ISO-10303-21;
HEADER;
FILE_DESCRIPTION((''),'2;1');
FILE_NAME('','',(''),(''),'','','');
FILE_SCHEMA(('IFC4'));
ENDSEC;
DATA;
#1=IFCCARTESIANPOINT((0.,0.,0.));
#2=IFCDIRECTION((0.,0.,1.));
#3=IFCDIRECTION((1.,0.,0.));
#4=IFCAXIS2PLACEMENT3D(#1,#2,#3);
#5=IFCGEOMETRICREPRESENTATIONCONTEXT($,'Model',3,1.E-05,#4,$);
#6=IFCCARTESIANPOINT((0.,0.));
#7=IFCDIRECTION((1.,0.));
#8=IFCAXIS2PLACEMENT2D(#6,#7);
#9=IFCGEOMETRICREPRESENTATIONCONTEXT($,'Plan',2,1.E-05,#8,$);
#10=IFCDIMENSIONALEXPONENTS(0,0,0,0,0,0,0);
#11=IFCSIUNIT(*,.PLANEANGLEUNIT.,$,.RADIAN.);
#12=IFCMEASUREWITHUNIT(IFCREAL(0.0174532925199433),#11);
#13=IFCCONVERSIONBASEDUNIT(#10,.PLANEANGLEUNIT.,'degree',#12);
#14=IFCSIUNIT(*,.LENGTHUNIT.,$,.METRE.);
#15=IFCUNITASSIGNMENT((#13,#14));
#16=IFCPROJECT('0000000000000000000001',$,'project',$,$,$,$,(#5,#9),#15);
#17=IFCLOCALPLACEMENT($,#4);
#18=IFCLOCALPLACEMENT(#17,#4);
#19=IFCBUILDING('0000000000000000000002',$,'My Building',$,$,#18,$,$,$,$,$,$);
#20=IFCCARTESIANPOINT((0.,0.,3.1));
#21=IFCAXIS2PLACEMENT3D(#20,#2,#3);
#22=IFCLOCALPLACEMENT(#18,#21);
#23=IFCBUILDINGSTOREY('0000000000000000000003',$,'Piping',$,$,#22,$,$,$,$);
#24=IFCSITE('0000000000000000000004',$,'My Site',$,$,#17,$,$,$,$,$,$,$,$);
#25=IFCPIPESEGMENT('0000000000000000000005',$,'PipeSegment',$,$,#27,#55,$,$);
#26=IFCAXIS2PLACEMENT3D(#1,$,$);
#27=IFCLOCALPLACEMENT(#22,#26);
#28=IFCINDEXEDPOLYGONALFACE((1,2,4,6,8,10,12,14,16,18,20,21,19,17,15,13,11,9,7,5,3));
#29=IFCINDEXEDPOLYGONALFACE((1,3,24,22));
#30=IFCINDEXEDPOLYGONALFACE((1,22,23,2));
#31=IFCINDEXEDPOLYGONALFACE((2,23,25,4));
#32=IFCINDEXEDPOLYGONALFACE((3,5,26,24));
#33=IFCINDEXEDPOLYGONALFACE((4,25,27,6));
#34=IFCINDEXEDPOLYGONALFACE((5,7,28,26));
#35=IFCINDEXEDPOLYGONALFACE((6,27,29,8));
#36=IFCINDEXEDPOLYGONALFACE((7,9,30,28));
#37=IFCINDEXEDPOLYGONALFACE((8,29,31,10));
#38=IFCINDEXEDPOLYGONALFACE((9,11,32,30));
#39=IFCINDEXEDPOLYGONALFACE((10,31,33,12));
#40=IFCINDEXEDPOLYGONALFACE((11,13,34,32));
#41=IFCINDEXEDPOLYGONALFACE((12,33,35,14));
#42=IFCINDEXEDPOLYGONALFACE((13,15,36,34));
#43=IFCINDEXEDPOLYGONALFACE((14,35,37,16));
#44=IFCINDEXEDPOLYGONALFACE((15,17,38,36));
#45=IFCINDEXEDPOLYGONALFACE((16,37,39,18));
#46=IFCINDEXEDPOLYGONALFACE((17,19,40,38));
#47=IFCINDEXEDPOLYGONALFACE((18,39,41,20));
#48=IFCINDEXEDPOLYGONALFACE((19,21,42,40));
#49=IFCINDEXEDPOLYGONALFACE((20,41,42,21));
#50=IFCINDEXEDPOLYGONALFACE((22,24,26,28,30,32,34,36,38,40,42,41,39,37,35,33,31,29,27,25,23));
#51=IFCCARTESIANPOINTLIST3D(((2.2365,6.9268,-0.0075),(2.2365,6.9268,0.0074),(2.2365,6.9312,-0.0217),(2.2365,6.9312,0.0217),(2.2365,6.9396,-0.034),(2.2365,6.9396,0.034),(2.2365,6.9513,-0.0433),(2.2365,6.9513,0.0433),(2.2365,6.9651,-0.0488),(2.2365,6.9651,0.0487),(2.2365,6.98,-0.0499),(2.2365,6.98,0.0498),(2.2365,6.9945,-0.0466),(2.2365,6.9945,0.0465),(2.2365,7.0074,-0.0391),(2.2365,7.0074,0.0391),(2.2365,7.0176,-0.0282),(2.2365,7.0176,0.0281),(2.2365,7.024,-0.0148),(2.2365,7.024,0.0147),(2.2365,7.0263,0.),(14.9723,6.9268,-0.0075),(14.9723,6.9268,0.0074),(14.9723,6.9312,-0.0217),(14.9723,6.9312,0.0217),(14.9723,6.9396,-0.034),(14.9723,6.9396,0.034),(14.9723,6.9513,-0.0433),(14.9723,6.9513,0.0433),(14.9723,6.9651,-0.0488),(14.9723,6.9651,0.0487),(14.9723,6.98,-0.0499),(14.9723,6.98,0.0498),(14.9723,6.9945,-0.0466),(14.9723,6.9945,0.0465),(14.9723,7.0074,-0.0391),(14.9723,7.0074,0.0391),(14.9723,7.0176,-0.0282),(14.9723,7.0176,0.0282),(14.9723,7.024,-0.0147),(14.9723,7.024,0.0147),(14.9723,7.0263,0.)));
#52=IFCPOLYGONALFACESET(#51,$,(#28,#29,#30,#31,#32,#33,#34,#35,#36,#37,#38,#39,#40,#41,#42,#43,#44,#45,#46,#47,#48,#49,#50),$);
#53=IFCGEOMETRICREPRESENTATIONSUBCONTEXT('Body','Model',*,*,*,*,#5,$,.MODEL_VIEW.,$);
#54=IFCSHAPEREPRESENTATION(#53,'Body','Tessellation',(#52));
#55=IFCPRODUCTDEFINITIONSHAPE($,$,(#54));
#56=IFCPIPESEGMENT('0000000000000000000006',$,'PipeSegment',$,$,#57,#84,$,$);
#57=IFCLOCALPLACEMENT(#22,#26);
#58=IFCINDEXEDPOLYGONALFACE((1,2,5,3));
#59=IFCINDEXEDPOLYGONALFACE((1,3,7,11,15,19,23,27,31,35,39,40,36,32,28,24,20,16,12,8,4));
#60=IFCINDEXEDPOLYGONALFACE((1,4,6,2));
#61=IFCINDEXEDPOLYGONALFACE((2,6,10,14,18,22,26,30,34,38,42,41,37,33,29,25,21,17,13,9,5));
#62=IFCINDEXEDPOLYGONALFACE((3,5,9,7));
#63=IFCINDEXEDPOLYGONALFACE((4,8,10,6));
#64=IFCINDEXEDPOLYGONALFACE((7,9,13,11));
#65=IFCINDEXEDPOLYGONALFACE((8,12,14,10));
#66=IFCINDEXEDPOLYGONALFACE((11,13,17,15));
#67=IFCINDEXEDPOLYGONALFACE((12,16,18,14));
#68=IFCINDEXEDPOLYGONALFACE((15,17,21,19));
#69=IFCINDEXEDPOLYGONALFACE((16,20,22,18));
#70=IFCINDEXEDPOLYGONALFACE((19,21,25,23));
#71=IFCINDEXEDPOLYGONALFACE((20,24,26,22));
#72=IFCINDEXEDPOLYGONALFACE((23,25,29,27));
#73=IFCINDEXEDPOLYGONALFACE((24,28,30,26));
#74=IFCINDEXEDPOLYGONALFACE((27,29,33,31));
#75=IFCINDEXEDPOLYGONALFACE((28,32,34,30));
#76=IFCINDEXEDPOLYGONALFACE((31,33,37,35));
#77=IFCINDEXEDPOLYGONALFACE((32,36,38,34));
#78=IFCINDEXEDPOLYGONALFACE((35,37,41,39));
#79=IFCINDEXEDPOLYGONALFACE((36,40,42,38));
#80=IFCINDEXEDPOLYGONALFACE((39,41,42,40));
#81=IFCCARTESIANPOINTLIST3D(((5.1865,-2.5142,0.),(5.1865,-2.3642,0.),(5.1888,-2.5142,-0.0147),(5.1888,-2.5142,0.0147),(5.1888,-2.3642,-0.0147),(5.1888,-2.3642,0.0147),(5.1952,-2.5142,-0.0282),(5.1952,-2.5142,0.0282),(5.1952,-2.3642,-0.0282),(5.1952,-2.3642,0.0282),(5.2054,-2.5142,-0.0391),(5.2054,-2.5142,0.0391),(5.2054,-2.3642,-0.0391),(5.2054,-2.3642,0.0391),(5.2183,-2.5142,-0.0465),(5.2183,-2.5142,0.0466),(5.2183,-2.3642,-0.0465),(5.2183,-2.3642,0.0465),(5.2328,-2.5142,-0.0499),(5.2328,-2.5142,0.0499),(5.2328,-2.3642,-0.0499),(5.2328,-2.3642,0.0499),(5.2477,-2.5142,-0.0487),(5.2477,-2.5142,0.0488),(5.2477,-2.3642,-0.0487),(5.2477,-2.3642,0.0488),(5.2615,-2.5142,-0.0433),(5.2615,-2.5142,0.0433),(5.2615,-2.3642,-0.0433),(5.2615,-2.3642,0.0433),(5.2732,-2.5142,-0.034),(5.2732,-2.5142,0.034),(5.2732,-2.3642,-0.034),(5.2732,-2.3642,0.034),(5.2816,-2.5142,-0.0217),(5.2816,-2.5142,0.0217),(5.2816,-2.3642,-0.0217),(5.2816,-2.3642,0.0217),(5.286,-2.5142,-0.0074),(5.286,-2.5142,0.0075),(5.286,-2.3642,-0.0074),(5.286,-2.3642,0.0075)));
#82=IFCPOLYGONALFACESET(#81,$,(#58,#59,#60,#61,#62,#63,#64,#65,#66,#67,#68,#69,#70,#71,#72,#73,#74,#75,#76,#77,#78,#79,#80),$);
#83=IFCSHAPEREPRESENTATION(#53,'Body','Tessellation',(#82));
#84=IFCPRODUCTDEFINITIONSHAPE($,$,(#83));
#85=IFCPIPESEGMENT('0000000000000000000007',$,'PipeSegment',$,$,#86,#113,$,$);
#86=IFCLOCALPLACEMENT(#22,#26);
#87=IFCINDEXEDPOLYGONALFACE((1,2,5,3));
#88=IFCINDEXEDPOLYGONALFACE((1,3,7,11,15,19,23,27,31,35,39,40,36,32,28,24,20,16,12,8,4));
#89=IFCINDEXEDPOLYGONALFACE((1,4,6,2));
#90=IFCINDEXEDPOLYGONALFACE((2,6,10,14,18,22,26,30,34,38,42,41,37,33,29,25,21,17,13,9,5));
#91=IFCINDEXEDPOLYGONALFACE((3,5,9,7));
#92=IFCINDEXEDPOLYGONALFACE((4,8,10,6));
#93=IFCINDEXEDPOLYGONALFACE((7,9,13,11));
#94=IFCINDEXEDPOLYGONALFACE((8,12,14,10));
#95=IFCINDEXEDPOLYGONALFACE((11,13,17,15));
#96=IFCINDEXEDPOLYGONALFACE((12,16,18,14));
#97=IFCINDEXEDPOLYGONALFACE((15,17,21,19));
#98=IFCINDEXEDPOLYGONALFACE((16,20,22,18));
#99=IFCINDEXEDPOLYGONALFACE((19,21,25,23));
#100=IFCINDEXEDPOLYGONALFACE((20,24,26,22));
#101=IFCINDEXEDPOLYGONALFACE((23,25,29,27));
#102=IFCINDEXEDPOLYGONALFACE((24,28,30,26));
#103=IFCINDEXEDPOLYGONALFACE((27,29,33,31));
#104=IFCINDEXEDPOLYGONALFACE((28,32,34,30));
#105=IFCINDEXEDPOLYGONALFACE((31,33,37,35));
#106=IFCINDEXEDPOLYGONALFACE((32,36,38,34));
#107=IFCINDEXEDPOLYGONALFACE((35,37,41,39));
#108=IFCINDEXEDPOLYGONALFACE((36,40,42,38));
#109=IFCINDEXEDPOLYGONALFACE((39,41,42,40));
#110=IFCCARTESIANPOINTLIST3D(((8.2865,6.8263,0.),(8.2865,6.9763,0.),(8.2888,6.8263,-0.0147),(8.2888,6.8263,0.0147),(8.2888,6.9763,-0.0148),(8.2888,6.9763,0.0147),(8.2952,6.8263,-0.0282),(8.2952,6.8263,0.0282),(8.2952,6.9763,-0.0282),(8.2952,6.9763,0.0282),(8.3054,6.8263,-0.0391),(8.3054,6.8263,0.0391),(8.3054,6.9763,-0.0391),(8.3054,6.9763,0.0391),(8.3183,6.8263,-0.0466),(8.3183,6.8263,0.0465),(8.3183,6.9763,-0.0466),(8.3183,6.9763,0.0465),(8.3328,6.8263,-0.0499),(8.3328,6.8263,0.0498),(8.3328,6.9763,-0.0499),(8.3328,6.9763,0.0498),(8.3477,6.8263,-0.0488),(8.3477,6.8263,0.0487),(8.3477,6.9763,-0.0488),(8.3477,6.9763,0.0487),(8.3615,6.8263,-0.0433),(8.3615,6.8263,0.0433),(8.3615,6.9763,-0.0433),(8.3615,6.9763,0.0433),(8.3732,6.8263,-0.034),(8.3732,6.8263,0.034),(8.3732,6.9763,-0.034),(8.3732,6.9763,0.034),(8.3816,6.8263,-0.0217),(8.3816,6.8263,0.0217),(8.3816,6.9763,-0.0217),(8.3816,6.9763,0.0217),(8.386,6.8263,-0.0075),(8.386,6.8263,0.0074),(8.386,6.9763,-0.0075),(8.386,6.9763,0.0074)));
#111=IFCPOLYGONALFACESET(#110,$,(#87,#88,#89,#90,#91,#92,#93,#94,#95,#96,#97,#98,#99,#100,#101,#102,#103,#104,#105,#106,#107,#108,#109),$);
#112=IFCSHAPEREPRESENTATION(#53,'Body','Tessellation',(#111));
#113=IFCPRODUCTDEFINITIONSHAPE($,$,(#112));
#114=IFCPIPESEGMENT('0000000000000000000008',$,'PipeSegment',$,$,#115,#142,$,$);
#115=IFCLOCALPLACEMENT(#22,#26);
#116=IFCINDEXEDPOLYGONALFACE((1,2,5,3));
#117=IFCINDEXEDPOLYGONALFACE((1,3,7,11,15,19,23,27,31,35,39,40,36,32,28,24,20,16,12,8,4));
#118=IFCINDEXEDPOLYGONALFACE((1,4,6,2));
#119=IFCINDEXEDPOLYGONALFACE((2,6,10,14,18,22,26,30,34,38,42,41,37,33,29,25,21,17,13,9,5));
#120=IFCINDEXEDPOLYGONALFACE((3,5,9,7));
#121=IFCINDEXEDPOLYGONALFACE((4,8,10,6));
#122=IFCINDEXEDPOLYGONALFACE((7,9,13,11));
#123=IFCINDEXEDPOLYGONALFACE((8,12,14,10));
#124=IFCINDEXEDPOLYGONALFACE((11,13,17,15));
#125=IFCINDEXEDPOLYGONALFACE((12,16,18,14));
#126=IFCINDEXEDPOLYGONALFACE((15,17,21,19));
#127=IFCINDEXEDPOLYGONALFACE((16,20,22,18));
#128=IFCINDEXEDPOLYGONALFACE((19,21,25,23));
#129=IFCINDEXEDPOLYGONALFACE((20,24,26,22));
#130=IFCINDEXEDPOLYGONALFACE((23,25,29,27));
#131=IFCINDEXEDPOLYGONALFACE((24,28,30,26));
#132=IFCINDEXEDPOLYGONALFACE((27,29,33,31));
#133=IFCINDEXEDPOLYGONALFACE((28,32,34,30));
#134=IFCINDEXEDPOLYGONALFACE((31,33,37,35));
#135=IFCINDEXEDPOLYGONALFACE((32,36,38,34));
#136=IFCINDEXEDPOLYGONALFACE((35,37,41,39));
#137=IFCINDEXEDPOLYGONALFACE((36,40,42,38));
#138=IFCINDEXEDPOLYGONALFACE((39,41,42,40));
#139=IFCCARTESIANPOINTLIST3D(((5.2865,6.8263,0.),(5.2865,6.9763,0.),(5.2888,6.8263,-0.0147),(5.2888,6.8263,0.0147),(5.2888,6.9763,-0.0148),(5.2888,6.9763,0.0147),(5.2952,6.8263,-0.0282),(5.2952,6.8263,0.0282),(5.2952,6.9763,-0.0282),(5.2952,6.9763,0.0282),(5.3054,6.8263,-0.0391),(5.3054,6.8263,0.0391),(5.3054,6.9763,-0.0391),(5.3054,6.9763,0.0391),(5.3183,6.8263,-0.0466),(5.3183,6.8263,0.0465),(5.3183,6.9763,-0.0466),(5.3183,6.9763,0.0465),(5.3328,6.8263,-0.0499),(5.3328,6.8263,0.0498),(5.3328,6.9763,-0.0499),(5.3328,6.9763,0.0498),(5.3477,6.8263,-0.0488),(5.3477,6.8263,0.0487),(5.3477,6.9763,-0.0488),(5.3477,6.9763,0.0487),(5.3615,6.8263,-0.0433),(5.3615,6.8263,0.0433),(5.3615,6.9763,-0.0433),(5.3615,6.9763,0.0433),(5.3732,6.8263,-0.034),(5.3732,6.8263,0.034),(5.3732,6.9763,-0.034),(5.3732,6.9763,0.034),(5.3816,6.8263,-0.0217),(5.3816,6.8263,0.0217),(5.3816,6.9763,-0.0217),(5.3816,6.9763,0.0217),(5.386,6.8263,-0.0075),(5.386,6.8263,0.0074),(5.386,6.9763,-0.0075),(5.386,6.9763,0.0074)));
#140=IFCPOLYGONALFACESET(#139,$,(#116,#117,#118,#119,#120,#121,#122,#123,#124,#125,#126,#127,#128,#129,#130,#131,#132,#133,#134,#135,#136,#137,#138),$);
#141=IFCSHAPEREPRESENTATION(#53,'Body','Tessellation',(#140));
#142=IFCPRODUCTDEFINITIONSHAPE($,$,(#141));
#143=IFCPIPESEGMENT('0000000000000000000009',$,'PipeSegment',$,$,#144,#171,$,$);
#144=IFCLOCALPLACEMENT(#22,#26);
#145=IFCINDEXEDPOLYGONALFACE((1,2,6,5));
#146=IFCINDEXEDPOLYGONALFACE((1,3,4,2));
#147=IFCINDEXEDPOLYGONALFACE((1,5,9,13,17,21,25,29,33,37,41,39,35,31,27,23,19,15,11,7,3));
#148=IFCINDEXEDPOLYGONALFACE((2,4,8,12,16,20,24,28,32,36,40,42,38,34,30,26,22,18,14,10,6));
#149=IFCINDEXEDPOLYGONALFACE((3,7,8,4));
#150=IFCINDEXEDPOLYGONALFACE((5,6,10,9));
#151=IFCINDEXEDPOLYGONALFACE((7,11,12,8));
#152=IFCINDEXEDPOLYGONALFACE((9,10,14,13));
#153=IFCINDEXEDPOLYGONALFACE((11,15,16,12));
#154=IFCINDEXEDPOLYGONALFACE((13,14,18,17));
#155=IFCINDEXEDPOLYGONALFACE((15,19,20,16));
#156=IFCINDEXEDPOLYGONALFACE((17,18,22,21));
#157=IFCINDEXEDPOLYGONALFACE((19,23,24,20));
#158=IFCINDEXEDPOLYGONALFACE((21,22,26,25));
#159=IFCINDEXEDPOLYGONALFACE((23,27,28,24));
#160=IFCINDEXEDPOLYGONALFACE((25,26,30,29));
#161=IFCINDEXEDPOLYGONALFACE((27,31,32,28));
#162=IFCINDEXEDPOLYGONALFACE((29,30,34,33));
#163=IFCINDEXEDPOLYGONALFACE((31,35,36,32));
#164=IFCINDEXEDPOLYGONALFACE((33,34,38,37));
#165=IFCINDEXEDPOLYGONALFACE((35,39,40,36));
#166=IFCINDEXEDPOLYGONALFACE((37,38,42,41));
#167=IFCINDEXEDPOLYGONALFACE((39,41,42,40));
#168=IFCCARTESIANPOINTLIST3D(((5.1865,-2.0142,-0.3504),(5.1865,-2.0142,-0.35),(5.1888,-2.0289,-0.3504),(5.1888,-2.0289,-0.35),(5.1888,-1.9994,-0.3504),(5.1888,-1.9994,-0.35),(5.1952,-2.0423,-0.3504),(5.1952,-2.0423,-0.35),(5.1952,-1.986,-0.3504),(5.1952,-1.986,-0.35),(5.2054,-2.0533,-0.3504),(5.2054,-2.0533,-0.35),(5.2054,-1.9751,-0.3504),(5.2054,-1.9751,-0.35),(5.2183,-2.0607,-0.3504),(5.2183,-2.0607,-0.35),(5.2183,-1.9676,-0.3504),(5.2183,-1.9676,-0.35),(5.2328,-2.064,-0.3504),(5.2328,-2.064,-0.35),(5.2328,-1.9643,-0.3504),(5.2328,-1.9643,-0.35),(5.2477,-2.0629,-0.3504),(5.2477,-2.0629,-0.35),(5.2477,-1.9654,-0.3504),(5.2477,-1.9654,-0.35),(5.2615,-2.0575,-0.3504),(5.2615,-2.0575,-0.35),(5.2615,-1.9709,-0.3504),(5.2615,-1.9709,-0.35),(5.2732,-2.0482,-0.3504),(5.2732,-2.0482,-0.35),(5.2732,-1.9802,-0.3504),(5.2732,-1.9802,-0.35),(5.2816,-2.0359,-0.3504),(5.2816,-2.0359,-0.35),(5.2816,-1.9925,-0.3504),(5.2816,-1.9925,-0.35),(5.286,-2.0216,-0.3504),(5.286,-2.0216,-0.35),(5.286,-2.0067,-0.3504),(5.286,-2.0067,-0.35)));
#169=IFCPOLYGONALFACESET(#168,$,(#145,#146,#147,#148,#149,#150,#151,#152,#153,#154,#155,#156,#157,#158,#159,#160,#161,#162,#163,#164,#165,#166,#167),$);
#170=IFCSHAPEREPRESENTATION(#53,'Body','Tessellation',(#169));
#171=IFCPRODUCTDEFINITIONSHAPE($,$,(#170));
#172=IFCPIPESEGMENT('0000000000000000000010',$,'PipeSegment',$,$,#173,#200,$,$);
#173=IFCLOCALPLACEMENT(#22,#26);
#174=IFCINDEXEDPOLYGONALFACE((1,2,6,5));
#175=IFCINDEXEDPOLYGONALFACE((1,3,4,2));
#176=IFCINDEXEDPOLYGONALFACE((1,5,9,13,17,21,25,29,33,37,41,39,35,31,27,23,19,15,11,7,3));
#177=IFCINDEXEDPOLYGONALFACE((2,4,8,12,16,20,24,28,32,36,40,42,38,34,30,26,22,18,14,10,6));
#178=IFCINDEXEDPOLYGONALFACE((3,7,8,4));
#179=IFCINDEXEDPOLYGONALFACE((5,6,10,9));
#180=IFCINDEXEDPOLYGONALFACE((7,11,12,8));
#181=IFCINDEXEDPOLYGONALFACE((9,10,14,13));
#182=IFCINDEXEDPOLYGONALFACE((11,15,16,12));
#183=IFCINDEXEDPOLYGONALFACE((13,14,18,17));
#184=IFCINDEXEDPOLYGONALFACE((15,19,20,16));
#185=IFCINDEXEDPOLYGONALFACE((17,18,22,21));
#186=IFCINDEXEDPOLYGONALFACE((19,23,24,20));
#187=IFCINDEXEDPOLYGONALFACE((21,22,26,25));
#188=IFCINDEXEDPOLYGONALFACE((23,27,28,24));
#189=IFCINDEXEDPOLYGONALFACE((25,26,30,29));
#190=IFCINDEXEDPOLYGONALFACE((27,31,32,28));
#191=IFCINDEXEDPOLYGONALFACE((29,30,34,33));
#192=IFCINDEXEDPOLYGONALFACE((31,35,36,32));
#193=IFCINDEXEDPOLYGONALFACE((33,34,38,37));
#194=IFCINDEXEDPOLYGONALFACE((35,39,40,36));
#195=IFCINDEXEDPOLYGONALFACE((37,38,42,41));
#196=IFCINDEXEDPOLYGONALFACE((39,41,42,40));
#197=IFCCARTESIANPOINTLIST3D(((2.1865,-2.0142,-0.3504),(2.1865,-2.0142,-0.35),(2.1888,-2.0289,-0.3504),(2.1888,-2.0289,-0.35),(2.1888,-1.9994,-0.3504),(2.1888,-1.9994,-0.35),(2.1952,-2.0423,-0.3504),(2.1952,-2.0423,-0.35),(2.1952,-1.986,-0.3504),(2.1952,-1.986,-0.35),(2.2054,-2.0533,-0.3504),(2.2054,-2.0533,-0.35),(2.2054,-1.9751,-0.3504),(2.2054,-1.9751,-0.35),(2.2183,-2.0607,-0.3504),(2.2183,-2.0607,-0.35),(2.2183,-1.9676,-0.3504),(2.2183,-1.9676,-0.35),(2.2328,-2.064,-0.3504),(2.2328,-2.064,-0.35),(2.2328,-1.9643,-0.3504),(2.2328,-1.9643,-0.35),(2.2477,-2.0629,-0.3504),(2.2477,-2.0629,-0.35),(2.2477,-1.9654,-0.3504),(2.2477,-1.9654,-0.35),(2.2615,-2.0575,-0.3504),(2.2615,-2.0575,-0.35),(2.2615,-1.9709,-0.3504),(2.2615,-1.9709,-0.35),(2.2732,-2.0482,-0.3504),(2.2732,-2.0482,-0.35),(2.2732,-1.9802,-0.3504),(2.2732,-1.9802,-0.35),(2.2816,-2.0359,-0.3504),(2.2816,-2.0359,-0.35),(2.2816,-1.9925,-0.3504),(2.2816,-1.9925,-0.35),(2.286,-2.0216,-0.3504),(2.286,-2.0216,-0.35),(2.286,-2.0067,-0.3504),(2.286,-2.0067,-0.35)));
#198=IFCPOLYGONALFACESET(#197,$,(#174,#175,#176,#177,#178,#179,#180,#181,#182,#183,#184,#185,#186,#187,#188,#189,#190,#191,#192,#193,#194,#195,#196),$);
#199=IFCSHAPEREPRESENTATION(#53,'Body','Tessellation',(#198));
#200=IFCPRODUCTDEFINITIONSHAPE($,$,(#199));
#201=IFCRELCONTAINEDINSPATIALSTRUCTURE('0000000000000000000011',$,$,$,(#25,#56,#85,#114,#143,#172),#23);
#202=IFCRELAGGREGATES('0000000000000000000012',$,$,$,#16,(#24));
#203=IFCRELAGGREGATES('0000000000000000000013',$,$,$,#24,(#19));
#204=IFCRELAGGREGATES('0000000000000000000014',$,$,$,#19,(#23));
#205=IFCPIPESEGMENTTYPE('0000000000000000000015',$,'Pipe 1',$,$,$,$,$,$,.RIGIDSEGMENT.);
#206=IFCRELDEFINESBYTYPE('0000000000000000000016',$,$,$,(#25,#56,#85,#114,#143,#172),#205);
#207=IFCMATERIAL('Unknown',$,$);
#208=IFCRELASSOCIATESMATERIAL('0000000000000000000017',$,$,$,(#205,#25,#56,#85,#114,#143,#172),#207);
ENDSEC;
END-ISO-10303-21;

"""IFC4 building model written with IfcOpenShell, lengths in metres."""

from ifc_helpers import new_model, entity, si_unit, converted_unit, frame, origin_with_axes, origin_2d_with_axis, place, context, subcontext, project, spatial, circle, extrude, material, material_profile, profile_set, profile_usage, type_object, element, save


model = new_model("IFC4")

# Units and contexts
model_context = context("Model", 3, precision=1e-05, world=origin_with_axes())
plan_context = context("Plan", 2, precision=1e-05, world=origin_2d_with_axis())
body_context = subcontext(model_context, "Body", "Model", "MODEL_VIEW")
ifc_project = project(units=[converted_unit("PLANEANGLEUNIT", "degree", entity("IfcReal", 0.0174532925199433), si_unit("PLANEANGLEUNIT", "RADIAN"), dimensions=[0, 0, 0, 0, 0, 0, 0]), si_unit("LENGTHUNIT", "METRE")], contexts=[model_context, plan_context])

# Site, building, storey
site_placement = place(None, origin_with_axes())
site = spatial("IfcSite", under=ifc_project, at=site_placement, Name="My Site")
building_placement = place(site_placement, origin_with_axes())
building = spatial("IfcBuilding", under=site, at=building_placement, Name="My Building")
storey_placement = place(building_placement, frame((0.0, 0.0, 3.1), z_axis=(0.0, 0.0, 1.0), x_axis=(1.0, 0.0, 0.0)))
storey = spatial("IfcBuildingStorey", under=building, at=storey_placement, Name="Piping")

# Pipe segments
ifc_material = material(Name="Unknown")
ifc_material_profile = material_profile(ifc_material, circle(Radius=0.05))
ifc_profile_set = profile_set([ifc_material_profile])
ifc_profile_usage_1 = profile_usage(ifc_profile_set, cardinal=5)
pipe_segment_type = type_object("IfcPipeSegmentType", Name="Pipe 1", PredefinedType="RIGIDSEGMENT", material=ifc_profile_set)
pipe_segment_1_placement = place(storey_placement, frame((2.2365, 6.9763, 0.0), z_axis=(1.0, 0.0, 0.0), x_axis=(0.0, 1.0, 0.0)))
element("IfcPipeSegment", 1, at=pipe_segment_1_placement, inside=storey, type_object=pipe_segment_type, material=ifc_profile_usage_1, Name="PipeSegment", context=body_context, shape_type="SweptSolid", body=[
    extrude(circle(Radius=0.05), origin_with_axes(), (0.0, 0.0, 1.0), 12.7358),
])
ifc_profile_usage_2 = profile_usage(ifc_profile_set, cardinal=5)
pipe_segment_2_placement = place(storey_placement, frame((5.2365, -2.5142, 0.0), z_axis=(0.0, 1.0, -0.000022), x_axis=(-1.0, 0.0, 0.0)))
element("IfcPipeSegment", 2, at=pipe_segment_2_placement, inside=storey, type_object=pipe_segment_type, material=ifc_profile_usage_2, Name="PipeSegment", context=body_context, shape_type="SweptSolid", body=[
    extrude(circle(Radius=0.05), origin_with_axes(), (0.0, 0.0, 1.0), 0.15),
])
ifc_profile_usage_3 = profile_usage(ifc_profile_set, cardinal=5)
pipe_segment_3_placement = place(storey_placement, frame((8.3365, 6.8263, 0.0), z_axis=(0.0, 1.0, -0.000022), x_axis=(-1.0, 0.0, 0.0)))
element("IfcPipeSegment", 3, at=pipe_segment_3_placement, inside=storey, type_object=pipe_segment_type, material=ifc_profile_usage_3, Name="PipeSegment", context=body_context, shape_type="SweptSolid", body=[
    extrude(circle(Radius=0.05), origin_with_axes(), (0.0, 0.0, 1.0), 0.15),
])
ifc_profile_usage_4 = profile_usage(ifc_profile_set, cardinal=5)
pipe_segment_4_placement = place(storey_placement, frame((5.3365, 6.8263, 0.0), z_axis=(0.0, 1.0, -0.000022), x_axis=(-1.0, 0.0, 0.0)))
element("IfcPipeSegment", 4, at=pipe_segment_4_placement, inside=storey, type_object=pipe_segment_type, material=ifc_profile_usage_4, Name="PipeSegment", context=body_context, shape_type="SweptSolid", body=[
    extrude(circle(Radius=0.05), origin_with_axes(), (0.0, 0.0, 1.0), 0.15),
])
ifc_profile_usage_5 = profile_usage(ifc_profile_set, cardinal=5)
pipe_segment_5_placement = place(storey_placement, frame((5.2365, -2.0142, -0.35), z_axis=(0.0, 0.0, -1.0), x_axis=(-1.0, 0.0, 0.0)))
element("IfcPipeSegment", 5, at=pipe_segment_5_placement, inside=storey, type_object=pipe_segment_type, material=ifc_profile_usage_5, Name="PipeSegment", context=body_context, shape_type="SweptSolid", body=[
    extrude(circle(Radius=0.05), origin_with_axes(), (0.0, 0.0, 1.0), 0.0004),
])
ifc_profile_usage_6 = profile_usage(ifc_profile_set, cardinal=5)
pipe_segment_6_placement = place(storey_placement, frame((2.2365, -2.0142, -0.35), z_axis=(0.0, 0.0, -1.0), x_axis=(-1.0, 0.0, 0.0)))
element("IfcPipeSegment", 6, at=pipe_segment_6_placement, inside=storey, type_object=pipe_segment_type, material=ifc_profile_usage_6, Name="PipeSegment", context=body_context, shape_type="SweptSolid", body=[
    extrude(circle(Radius=0.05), origin_with_axes(), (0.0, 0.0, 1.0), 0.0004),
])

save(model, "model.ifc")
